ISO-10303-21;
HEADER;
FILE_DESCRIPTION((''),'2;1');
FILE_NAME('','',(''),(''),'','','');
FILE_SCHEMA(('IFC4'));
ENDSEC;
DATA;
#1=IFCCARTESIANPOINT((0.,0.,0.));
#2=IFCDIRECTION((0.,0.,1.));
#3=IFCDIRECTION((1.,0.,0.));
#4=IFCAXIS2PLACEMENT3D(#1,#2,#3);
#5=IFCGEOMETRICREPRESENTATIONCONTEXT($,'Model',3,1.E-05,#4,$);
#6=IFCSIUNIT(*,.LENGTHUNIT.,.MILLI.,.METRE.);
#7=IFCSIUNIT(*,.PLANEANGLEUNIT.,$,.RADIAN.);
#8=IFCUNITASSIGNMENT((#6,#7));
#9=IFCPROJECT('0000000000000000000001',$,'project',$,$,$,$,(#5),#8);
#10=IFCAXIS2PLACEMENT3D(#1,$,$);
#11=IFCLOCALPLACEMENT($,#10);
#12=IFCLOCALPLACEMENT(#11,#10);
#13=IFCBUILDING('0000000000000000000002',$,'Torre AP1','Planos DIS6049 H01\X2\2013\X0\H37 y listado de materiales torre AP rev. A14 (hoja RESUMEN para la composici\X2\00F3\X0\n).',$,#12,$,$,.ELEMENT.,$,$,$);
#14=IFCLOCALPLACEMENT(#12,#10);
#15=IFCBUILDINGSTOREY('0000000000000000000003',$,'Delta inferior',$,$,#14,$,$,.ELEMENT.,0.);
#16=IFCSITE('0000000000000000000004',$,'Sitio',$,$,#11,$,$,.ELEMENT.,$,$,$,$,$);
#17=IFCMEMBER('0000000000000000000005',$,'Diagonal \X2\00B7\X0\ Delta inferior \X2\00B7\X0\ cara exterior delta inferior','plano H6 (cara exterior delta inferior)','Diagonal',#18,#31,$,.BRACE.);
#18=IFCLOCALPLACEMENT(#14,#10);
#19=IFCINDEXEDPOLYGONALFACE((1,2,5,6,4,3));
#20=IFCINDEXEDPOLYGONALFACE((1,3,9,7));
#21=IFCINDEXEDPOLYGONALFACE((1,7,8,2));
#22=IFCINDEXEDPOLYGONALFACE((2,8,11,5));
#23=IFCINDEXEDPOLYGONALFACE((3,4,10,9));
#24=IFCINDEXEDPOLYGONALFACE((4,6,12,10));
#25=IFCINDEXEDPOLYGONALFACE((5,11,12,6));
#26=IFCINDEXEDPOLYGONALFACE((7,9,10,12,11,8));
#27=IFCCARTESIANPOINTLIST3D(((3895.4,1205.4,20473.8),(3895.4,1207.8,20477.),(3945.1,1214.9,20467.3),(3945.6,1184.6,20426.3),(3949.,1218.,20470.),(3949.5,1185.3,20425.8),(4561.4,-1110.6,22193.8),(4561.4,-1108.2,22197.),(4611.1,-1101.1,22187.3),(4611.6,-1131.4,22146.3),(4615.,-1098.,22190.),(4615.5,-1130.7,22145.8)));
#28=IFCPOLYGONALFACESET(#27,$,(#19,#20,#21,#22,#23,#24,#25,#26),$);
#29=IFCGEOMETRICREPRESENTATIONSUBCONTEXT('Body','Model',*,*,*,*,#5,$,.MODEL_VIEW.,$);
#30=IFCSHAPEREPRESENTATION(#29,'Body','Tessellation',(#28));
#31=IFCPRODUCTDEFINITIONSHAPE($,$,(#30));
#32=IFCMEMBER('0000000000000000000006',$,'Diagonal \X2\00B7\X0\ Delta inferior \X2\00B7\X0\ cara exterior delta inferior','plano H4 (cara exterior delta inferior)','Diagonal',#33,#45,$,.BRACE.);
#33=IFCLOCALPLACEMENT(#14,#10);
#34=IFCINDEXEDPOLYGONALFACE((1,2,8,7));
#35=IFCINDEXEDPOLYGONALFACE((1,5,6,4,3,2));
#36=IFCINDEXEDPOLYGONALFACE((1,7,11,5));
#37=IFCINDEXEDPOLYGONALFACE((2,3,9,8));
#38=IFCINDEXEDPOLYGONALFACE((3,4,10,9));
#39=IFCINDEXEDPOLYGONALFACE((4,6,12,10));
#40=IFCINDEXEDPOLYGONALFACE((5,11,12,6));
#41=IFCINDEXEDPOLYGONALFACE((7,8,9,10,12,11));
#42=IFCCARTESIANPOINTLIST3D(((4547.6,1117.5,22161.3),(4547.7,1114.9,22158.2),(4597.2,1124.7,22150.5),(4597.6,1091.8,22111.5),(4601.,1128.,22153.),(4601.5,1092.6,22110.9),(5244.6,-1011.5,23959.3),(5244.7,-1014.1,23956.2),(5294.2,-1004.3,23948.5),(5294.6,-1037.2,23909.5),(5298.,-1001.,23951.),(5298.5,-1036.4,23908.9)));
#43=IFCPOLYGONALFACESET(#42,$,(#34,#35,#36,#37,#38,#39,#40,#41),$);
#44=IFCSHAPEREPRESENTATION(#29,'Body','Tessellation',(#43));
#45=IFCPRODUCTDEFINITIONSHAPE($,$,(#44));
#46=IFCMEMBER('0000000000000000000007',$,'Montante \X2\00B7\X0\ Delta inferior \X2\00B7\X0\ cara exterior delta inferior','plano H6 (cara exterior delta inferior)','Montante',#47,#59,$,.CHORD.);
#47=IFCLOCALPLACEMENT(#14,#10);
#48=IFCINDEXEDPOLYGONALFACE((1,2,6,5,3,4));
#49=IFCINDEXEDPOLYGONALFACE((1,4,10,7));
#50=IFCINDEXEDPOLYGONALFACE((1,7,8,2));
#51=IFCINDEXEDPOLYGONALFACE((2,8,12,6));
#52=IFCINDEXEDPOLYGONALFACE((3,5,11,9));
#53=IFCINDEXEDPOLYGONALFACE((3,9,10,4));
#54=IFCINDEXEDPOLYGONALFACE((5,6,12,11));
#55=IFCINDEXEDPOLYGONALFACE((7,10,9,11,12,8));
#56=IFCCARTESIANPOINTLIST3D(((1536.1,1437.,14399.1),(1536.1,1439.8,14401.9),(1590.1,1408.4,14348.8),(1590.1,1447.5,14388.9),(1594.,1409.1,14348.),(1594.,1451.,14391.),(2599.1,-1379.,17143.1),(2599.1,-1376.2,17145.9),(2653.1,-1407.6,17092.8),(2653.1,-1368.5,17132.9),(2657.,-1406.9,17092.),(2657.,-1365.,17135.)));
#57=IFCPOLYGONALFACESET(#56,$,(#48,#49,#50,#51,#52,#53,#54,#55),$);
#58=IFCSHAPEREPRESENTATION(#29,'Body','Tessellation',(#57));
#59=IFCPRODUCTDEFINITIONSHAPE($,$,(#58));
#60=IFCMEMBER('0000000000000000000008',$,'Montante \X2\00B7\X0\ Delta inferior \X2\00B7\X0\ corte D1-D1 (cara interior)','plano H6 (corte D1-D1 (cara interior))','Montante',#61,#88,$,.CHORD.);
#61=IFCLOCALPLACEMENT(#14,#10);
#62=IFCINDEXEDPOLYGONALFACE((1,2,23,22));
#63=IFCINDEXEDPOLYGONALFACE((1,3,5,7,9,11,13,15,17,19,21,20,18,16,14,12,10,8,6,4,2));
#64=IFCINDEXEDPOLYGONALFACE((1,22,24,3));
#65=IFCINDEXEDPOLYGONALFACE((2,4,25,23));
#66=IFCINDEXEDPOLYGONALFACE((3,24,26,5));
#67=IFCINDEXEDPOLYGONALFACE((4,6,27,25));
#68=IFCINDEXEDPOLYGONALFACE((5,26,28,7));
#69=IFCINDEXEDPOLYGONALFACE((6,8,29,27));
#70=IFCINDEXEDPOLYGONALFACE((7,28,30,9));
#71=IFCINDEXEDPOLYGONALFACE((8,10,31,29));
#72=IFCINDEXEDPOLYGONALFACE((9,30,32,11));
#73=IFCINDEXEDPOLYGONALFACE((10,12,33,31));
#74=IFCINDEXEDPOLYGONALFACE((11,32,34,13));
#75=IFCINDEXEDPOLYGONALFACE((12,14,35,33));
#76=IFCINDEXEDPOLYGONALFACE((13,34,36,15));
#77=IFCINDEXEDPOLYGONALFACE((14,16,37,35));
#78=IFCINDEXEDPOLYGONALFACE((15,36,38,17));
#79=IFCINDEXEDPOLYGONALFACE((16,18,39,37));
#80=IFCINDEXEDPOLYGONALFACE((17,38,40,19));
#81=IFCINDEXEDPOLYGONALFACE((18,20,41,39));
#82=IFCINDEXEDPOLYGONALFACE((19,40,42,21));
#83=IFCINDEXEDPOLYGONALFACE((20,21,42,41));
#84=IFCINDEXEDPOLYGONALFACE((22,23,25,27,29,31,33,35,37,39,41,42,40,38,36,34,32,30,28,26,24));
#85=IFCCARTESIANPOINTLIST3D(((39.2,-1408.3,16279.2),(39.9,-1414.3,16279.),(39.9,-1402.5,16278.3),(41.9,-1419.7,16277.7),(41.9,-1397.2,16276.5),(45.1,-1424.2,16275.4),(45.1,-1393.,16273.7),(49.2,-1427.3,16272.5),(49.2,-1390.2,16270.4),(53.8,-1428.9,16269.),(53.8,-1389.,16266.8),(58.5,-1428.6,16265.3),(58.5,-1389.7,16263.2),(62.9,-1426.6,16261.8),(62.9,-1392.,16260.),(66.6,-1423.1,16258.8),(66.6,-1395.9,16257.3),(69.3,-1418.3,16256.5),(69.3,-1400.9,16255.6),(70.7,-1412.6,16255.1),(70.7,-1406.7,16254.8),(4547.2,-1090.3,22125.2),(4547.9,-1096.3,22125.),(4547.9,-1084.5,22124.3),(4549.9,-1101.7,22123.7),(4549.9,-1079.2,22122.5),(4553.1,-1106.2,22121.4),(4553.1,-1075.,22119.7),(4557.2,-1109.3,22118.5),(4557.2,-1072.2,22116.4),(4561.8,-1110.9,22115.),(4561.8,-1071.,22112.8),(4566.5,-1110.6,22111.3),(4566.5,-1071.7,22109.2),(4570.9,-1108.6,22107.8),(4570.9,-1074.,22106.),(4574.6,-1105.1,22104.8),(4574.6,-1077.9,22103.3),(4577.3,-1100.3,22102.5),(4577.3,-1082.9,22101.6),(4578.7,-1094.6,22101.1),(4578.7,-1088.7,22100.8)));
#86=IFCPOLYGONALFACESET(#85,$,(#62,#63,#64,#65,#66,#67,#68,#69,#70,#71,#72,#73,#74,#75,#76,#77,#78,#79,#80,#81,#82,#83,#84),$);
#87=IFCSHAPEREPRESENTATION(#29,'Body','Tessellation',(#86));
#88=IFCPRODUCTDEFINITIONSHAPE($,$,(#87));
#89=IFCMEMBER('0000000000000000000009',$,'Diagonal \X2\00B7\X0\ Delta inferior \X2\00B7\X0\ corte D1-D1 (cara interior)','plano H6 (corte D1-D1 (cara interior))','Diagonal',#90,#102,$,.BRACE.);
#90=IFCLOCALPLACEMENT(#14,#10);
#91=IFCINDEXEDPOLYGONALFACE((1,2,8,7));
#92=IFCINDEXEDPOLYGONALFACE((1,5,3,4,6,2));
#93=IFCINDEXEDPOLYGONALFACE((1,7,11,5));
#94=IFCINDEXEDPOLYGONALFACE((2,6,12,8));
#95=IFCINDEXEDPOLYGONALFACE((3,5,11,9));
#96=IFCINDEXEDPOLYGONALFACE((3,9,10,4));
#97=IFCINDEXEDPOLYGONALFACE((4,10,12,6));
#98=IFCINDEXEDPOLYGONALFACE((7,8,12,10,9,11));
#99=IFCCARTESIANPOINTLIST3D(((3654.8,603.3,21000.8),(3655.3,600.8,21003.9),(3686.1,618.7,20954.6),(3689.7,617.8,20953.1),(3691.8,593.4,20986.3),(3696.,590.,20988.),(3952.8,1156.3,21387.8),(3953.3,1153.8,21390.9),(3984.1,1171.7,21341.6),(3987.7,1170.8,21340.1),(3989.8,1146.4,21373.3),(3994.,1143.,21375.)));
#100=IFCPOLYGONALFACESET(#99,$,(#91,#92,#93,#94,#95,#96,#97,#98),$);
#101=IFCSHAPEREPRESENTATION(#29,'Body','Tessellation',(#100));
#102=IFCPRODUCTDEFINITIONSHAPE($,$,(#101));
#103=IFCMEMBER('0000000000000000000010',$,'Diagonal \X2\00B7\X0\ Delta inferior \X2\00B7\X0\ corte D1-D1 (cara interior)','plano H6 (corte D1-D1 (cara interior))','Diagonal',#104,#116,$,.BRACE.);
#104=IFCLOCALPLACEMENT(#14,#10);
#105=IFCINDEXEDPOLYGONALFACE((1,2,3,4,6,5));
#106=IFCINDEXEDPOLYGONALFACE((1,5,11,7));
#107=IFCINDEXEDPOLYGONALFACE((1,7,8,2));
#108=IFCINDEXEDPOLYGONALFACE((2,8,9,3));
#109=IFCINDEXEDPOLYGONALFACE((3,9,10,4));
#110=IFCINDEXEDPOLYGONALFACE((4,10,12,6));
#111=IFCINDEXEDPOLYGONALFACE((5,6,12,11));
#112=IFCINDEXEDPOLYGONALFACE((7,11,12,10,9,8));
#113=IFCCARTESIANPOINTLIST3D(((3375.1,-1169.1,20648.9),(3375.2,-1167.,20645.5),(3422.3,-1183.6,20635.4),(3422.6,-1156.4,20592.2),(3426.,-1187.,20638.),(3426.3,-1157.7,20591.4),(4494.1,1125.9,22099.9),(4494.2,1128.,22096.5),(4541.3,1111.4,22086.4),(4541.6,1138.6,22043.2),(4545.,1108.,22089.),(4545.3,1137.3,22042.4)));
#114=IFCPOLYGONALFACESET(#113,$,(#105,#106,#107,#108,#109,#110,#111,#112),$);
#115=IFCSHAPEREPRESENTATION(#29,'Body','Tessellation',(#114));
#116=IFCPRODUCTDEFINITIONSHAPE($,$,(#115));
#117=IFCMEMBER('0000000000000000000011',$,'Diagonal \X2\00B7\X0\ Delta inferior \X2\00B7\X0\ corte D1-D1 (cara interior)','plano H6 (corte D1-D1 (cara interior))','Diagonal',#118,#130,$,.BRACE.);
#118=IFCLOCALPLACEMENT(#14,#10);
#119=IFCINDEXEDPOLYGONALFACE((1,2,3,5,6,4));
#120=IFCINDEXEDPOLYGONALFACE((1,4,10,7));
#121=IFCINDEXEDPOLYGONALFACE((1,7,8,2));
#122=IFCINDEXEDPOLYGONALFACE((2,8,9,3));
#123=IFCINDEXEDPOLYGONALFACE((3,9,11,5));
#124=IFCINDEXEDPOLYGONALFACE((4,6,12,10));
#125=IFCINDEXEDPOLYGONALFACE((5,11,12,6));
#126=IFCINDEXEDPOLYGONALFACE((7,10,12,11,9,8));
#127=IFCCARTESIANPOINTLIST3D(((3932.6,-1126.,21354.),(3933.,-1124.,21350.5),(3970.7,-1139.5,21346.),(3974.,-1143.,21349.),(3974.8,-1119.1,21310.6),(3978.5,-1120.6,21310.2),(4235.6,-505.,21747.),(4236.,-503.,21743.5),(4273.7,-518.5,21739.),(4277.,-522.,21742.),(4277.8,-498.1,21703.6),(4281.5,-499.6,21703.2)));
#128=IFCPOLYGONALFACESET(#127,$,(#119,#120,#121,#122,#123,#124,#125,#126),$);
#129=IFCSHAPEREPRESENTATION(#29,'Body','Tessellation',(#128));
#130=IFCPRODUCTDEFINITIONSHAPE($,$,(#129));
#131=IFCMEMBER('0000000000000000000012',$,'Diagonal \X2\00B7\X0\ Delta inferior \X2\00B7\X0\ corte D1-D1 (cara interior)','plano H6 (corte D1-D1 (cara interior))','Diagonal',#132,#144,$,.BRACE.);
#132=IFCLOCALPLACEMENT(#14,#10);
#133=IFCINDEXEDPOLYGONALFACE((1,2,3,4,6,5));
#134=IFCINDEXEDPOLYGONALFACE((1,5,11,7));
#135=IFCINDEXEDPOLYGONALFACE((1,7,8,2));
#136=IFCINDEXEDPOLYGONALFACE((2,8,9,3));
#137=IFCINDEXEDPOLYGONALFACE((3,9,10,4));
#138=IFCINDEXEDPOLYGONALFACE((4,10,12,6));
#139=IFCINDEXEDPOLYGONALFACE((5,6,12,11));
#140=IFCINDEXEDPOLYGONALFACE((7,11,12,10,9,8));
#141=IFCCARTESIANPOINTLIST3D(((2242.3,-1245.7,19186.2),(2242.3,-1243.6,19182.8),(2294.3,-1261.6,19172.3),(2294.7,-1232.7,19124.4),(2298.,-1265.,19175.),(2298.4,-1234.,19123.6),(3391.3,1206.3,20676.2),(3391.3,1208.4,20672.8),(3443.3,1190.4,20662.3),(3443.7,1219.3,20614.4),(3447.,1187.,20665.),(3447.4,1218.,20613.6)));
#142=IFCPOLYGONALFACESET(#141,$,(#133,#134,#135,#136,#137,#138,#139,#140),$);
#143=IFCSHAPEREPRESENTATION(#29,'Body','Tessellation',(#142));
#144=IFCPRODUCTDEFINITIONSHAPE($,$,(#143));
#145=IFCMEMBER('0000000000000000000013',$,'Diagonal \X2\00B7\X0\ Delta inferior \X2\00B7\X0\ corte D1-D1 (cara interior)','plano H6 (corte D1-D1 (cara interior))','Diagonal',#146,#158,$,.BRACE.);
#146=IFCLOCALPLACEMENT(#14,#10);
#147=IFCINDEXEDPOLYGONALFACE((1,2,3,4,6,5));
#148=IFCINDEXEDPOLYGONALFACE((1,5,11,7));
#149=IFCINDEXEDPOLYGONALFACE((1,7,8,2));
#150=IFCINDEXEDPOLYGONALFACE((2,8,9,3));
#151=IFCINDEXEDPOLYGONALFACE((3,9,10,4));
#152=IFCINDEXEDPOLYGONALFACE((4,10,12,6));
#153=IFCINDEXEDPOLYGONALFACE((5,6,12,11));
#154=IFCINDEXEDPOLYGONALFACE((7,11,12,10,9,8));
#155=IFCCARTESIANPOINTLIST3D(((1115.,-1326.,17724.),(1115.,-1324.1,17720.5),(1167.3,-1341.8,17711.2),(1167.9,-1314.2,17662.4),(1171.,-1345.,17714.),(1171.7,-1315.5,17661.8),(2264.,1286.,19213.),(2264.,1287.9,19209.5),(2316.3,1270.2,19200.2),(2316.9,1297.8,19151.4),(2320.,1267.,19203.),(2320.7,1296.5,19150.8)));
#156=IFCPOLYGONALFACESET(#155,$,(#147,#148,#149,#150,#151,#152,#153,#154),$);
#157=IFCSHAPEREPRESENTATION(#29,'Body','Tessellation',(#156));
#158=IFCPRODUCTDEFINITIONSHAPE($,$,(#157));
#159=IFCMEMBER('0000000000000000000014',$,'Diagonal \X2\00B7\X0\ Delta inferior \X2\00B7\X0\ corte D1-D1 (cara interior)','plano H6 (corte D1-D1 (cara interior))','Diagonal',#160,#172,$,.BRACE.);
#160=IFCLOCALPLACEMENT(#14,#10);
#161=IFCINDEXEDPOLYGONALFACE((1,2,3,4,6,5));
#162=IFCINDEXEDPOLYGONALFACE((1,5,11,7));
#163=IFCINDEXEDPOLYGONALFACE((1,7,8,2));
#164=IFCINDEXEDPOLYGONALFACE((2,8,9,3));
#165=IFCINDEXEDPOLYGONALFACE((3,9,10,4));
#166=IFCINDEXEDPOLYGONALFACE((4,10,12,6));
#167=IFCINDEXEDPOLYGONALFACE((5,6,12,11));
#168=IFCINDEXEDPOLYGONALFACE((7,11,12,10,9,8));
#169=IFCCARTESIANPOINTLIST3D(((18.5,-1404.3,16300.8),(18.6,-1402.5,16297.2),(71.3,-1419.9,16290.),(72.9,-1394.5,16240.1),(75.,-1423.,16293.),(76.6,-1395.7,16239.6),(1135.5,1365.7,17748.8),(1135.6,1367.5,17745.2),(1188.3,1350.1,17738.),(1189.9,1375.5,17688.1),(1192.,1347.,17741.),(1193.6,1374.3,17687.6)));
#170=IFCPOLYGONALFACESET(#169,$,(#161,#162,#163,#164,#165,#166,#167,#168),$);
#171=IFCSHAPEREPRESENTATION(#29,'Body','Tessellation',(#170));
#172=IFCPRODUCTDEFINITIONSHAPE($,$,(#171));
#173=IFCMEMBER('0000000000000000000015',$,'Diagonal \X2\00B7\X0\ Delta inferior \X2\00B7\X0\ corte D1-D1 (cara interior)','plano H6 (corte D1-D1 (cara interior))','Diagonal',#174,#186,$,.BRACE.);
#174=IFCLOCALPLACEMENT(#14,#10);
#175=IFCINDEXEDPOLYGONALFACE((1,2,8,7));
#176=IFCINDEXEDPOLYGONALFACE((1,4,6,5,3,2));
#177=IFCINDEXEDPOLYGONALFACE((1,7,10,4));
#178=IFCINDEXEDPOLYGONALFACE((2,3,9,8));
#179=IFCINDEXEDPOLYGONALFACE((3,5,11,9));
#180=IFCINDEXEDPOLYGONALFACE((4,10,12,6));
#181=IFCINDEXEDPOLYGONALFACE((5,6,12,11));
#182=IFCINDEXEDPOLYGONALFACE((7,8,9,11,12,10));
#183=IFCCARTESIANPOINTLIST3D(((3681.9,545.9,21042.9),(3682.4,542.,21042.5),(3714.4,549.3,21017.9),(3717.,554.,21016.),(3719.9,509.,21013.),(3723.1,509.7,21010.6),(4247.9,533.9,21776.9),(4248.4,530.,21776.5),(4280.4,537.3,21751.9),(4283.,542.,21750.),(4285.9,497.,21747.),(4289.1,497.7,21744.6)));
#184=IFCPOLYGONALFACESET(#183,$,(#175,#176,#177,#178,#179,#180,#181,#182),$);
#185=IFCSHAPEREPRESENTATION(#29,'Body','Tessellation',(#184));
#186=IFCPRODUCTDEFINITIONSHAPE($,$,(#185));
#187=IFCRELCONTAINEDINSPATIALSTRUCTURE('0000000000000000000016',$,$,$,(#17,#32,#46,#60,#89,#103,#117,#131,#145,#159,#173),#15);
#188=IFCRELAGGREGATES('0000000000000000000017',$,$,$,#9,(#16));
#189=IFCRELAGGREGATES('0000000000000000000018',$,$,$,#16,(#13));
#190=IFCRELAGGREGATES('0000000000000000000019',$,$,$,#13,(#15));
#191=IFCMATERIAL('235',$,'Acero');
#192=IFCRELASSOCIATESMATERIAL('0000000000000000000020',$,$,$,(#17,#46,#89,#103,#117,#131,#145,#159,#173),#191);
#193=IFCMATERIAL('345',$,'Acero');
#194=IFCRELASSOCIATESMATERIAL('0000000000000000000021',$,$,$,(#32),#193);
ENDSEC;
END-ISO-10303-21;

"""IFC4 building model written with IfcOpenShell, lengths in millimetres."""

from ifc_helpers import new_model, si_unit, frame, frame_2d, origin, origin_with_axes, place, context, subcontext, project, spatial, circle, l_section, extrude, material, element, save


model = new_model("IFC4")

# Units and contexts
model_context = context("Model", 3, precision=1e-05, world=origin_with_axes())
body_context = subcontext(model_context, "Body", "Model", "MODEL_VIEW")
ifc_project = project(units=[si_unit("LENGTHUNIT", "METRE", prefix="MILLI"), si_unit("PLANEANGLEUNIT", "RADIAN")], contexts=[model_context])

# Site, building, storey
site_placement = place(None, origin())
site = spatial("IfcSite", under=ifc_project, at=site_placement, Name="Sitio", CompositionType="ELEMENT")
building_placement = place(site_placement, origin())
building = spatial("IfcBuilding", under=site, at=building_placement, Name="Torre AP1", Description="Planos DIS6049 H01–H37 y listado de materiales torre AP rev. A14 (hoja RESUMEN para la composición).", CompositionType="ELEMENT")
storey_placement = place(building_placement, origin())
storey = spatial("IfcBuildingStorey", under=building, at=storey_placement, Name="Delta inferior", CompositionType="ELEMENT", Elevation=0.0)

# Members
ifc_material_1 = material(Name="235", Category="Acero")
ifc_material_2 = material(Name="345", Category="Acero")
member_1_placement = place(storey_placement, frame((3949.0, 1218.0, 20470.0), z_axis=(0.224946, -0.782244, 0.580941), x_axis=(-0.974336, -0.185683, 0.127247)))
element("IfcMember", 1, at=member_1_placement, inside=storey, material=ifc_material_1, Name="Diagonal · Delta inferior · cara exterior delta inferior", Description="plano H6 (cara exterior delta inferior)", ObjectType="Diagonal", PredefinedType="BRACE", context=body_context, shape_type="SweptSolid", body=[
    extrude(l_section(Depth=55.0, Width=55.0, Thickness=4.0, at=frame_2d((27.5, 27.5))), None, (0.0, 0.0, 1.0), 2960.7),
])
member_2_placement = place(storey_placement, frame((4601.0, 1128.0, 22153.0), z_axis=(0.242646, -0.741166, 0.625936), x_axis=(-0.97008, -0.190866, 0.150051)))
element("IfcMember", 2, at=member_2_placement, inside=storey, material=ifc_material_2, Name="Diagonal · Delta inferior · cara exterior delta inferior", Description="plano H4 (cara exterior delta inferior)", ObjectType="Diagonal", PredefinedType="BRACE", context=body_context, shape_type="SweptSolid", body=[
    extrude(l_section(Depth=55.0, Width=55.0, Thickness=4.0, at=frame_2d((27.5, 27.5))), None, (0.0, 0.0, 1.0), 2872.5),
])
member_3_placement = place(storey_placement, frame((1594.0, 1451.0, 14391.0), z_axis=(0.260987, -0.691382, 0.673704), x_axis=(-0.965342, -0.18692, 0.18214)))
element("IfcMember", 3, at=member_3_placement, inside=storey, material=ifc_material_1, Name="Montante · Delta inferior · cara exterior delta inferior", Description="plano H6 (cara exterior delta inferior)", ObjectType="Montante", PredefinedType="CHORD", context=body_context, shape_type="SweptSolid", body=[
    extrude(l_section(Depth=60.0, Width=60.0, Thickness=4.0, at=frame_2d((30.0, 30.0))), None, (0.0, 0.0, 1.0), 4073.0),
])
member_4_placement = place(storey_placement, frame((4563.0, -1091.0, 22113.0), z_axis=(-0.610087, -0.043036, -0.791165), x_axis=(-0.792334, 0.033137, 0.609187)))
element("IfcMember", 4, at=member_4_placement, inside=storey, Name="Montante · Delta inferior · corte D1-D1 (cara interior)", Description="plano H6 (corte D1-D1 (cara interior))", ObjectType="Montante", PredefinedType="CHORD", context=body_context, shape_type="SweptSolid", body=[
    extrude(circle(Radius=20.0), None, (0.0, 0.0, 1.0), 7389.1),
])
member_5_placement = place(storey_placement, frame((3994.0, 1143.0, 21375.0), z_axis=(-0.403891, -0.749503, -0.524516), x_axis=(-0.904178, 0.239916, 0.353414)))
element("IfcMember", 5, at=member_5_placement, inside=storey, material=ifc_material_1, Name="Diagonal · Delta inferior · corte D1-D1 (cara interior)", Description="plano H6 (corte D1-D1 (cara interior))", ObjectType="Diagonal", PredefinedType="BRACE", context=body_context, shape_type="SweptSolid", body=[
    extrude(l_section(Depth=45.0, Width=45.0, Thickness=4.0, at=frame_2d((22.5, 22.5))), None, (0.0, 0.0, 1.0), 737.8),
])
member_6_placement = place(storey_placement, frame((4545.0, 1108.0, 22089.0), z_axis=(-0.381032, -0.781472, -0.494081), x_axis=(-0.924547, 0.325107, 0.198793)))
element("IfcMember", 6, at=member_6_placement, inside=storey, material=ifc_material_1, Name="Diagonal · Delta inferior · corte D1-D1 (cara interior)", Description="plano H6 (corte D1-D1 (cara interior))", ObjectType="Diagonal", PredefinedType="BRACE", context=body_context, shape_type="SweptSolid", body=[
    extrude(l_section(Depth=55.0, Width=55.0, Thickness=4.0, at=frame_2d((27.5, 27.5))), None, (0.0, 0.0, 1.0), 2936.8),
])
member_7_placement = place(storey_placement, frame((4277.0, -522.0, 21742.0), z_axis=(-0.38117, -0.78121, -0.494389), x_axis=(-0.919056, 0.378167, 0.111023)))
element("IfcMember", 7, at=member_7_placement, inside=storey, material=ifc_material_1, Name="Diagonal · Delta inferior · corte D1-D1 (cara interior)", Description="plano H6 (corte D1-D1 (cara interior))", ObjectType="Diagonal", PredefinedType="BRACE", context=body_context, shape_type="SweptSolid", body=[
    extrude(l_section(Depth=45.0, Width=45.0, Thickness=4.0, at=frame_2d((22.5, 22.5))), None, (0.0, 0.0, 1.0), 794.9),
])
member_8_placement = place(storey_placement, frame((3447.0, 1187.0, 20665.0), z_axis=(-0.371757, -0.79334, -0.482087), x_axis=(-0.928304, 0.321616, 0.18659)))
element("IfcMember", 8, at=member_8_placement, inside=storey, material=ifc_material_1, Name="Diagonal · Delta inferior · corte D1-D1 (cara interior)", Description="plano H6 (corte D1-D1 (cara interior))", ObjectType="Diagonal", PredefinedType="BRACE", context=body_context, shape_type="SweptSolid", body=[
    extrude(l_section(Depth=60.0, Width=60.0, Thickness=4.0, at=frame_2d((30.0, 30.0))), None, (0.0, 0.0, 1.0), 3090.7),
])
member_9_placement = place(storey_placement, frame((2320.0, 1267.0, 19203.0), z_axis=(-0.356979, -0.811514, -0.462613), x_axis=(-0.934048, 0.315929, 0.166565)))
element("IfcMember", 9, at=member_9_placement, inside=storey, material=ifc_material_1, Name="Diagonal · Delta inferior · corte D1-D1 (cara interior)", Description="plano H6 (corte D1-D1 (cara interior))", ObjectType="Diagonal", PredefinedType="BRACE", context=body_context, shape_type="SweptSolid", body=[
    extrude(l_section(Depth=60.0, Width=60.0, Thickness=4.0, at=frame_2d((30.0, 30.0))), None, (0.0, 0.0, 1.0), 3218.7),
])
member_10_placement = place(storey_placement, frame((1192.0, 1347.0, 17741.0), z_axis=(-0.336524, -0.834531, -0.436246), x_axis=(-0.94128, 0.311519, 0.130181)))
element("IfcMember", 10, at=member_10_placement, inside=storey, material=ifc_material_1, Name="Diagonal · Delta inferior · corte D1-D1 (cara interior)", Description="plano H6 (corte D1-D1 (cara interior))", ObjectType="Diagonal", PredefinedType="BRACE", context=body_context, shape_type="SweptSolid", body=[
    extrude(l_section(Depth=60.0, Width=60.0, Thickness=4.0, at=frame_2d((30.0, 30.0))), None, (0.0, 0.0, 1.0), 3319.2),
])
member_11_placement = place(storey_placement, frame((3717.0, 554.0, 21016.0), z_axis=(0.610598, -0.012946, 0.791835), x_axis=(-0.780393, -0.179966, 0.598832)))
element("IfcMember", 11, at=member_11_placement, inside=storey, material=ifc_material_1, Name="Diagonal · Delta inferior · corte D1-D1 (cara interior)", Description="plano H6 (corte D1-D1 (cara interior))", ObjectType="Diagonal", PredefinedType="BRACE", context=body_context, shape_type="SweptSolid", body=[
    extrude(l_section(Depth=45.0, Width=45.0, Thickness=4.0, at=frame_2d((22.5, 22.5))), None, (0.0, 0.0, 1.0), 927.0),
])

save(model, "model.ifc")
